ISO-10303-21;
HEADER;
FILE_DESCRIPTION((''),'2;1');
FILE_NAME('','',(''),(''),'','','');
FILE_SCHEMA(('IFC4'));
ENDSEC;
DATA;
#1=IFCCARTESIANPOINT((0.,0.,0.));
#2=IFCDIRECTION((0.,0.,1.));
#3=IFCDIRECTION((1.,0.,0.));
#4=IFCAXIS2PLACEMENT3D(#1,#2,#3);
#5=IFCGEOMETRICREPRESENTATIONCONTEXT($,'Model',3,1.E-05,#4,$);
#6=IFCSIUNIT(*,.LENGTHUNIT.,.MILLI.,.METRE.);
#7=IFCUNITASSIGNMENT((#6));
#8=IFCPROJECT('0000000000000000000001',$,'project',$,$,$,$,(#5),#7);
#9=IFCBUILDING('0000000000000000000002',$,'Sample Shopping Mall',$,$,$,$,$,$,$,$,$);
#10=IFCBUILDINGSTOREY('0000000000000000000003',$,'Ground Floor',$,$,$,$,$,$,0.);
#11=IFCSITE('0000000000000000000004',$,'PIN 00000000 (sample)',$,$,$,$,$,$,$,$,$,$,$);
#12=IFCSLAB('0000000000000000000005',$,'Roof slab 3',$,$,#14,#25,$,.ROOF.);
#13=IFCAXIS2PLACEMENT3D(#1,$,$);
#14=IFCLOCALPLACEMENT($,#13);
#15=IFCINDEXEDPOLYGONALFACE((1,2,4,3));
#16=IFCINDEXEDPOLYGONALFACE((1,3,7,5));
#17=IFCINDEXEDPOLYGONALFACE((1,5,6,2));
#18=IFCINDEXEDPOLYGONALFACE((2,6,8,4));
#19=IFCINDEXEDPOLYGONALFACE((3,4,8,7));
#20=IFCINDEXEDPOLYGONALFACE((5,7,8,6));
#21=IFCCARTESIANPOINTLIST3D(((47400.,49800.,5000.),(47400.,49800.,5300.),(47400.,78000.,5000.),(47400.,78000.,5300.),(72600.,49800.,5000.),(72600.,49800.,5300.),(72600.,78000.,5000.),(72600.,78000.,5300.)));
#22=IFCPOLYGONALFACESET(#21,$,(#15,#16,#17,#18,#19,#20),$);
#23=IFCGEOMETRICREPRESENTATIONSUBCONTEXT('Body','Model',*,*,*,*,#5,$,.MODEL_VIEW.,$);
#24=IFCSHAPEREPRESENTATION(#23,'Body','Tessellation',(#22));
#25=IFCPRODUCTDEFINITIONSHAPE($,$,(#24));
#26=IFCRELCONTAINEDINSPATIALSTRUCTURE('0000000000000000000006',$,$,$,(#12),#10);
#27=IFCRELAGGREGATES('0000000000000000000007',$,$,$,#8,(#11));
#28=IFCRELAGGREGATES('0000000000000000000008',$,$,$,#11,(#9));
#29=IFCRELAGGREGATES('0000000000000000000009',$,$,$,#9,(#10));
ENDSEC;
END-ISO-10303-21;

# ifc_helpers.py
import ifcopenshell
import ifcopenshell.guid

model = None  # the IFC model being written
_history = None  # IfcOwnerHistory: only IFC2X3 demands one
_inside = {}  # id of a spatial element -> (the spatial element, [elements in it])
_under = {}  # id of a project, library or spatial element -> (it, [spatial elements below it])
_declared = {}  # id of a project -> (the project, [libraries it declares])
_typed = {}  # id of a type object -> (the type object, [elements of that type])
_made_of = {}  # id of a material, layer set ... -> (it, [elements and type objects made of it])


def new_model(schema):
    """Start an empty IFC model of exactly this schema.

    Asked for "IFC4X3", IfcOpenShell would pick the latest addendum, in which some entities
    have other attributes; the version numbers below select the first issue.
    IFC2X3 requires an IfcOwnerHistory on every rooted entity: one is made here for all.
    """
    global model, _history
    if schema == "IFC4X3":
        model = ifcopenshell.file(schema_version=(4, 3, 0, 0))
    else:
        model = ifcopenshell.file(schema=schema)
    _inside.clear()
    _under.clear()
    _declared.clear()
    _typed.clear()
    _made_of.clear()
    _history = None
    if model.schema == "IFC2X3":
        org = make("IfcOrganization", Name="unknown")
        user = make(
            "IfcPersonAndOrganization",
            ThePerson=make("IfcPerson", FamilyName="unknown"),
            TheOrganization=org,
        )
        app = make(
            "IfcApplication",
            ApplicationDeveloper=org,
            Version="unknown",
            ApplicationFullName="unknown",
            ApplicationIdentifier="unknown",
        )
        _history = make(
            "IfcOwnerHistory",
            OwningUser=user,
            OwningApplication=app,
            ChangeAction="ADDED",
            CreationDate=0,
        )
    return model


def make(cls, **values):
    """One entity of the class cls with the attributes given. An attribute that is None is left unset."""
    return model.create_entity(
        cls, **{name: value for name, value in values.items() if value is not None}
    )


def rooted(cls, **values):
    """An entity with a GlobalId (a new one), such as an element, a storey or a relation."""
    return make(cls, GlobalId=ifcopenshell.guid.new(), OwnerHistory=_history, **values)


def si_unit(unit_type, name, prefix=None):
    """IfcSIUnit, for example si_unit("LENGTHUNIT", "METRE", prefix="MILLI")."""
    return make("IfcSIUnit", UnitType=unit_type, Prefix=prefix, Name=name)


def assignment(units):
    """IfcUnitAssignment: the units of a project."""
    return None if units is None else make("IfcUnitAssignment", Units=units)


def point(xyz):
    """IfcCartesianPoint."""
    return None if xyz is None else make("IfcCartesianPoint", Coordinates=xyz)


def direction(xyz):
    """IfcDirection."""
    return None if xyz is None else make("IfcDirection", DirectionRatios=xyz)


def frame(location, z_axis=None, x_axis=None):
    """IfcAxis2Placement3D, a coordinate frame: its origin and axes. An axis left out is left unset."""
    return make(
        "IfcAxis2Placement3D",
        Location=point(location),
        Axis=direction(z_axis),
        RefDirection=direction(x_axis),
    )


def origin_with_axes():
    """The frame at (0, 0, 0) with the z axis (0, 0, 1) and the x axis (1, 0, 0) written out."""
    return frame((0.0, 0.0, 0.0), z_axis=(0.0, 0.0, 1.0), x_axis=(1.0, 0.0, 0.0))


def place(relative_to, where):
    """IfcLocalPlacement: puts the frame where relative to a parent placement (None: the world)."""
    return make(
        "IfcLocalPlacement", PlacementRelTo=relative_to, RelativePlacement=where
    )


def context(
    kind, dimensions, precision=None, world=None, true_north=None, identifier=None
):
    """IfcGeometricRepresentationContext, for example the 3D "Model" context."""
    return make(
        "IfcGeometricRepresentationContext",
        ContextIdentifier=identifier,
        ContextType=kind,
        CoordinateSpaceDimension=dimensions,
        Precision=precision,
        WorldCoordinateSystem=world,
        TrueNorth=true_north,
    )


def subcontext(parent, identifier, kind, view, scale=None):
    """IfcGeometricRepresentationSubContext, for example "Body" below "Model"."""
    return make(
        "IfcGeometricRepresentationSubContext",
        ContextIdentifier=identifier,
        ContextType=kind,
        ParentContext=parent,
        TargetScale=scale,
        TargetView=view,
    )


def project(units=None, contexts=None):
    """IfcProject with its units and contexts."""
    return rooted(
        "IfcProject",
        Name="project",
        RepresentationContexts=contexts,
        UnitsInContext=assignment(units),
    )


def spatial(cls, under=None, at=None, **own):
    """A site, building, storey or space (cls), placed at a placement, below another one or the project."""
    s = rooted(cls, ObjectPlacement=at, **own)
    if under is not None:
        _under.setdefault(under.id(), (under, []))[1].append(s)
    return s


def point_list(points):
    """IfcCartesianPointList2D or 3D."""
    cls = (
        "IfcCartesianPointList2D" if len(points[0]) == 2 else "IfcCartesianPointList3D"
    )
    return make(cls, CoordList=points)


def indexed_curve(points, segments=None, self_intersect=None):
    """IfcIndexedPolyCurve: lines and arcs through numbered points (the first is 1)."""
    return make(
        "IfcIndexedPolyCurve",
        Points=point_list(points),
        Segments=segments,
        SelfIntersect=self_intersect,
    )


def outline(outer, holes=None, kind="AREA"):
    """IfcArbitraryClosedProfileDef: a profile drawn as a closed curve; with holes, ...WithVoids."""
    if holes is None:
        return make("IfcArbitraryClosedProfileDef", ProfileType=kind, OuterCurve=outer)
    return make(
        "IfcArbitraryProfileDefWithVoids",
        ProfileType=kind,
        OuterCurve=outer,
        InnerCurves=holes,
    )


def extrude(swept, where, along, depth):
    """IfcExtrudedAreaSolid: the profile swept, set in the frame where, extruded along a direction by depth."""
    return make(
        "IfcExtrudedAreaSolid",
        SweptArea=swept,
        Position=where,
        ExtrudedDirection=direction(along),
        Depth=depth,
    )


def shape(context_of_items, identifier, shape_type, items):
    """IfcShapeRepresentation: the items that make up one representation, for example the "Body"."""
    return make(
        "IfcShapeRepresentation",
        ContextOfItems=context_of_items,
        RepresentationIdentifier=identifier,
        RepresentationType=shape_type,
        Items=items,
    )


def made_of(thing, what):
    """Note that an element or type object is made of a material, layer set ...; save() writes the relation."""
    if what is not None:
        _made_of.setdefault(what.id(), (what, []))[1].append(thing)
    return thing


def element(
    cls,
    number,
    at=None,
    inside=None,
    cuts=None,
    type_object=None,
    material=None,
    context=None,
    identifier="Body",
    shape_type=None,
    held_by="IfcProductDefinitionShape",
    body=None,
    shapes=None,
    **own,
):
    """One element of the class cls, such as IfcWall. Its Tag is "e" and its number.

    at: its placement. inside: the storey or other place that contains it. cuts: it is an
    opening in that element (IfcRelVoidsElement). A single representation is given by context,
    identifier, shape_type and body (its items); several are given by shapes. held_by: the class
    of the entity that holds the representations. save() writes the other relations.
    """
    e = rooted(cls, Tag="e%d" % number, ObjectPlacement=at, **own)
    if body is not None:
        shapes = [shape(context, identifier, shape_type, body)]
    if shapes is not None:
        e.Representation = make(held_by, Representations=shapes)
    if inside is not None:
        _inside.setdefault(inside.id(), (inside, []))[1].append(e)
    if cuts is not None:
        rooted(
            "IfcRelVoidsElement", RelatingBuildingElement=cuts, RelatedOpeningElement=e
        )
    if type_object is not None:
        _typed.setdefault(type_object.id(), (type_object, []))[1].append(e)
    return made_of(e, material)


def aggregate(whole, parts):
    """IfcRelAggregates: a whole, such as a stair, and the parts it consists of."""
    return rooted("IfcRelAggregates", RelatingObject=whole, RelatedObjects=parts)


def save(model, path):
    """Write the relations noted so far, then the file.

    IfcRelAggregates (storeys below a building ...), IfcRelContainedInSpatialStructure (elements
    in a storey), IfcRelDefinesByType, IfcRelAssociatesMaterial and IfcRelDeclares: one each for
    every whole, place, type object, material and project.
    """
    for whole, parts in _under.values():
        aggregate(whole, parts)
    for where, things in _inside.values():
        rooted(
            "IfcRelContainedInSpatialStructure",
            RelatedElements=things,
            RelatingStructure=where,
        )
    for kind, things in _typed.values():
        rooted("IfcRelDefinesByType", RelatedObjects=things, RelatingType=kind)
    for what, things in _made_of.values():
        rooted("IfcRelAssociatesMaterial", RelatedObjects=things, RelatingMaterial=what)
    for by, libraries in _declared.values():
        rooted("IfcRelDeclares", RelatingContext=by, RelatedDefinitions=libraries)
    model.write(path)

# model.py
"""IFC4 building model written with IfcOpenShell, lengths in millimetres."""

from ifc_helpers import new_model, si_unit, frame, origin_with_axes, place, context, subcontext, project, spatial, indexed_curve, outline, extrude, element, save


model = new_model("IFC4")

# Units and contexts
model_context = context("Model", 3, precision=1e-05, world=origin_with_axes())
body_context = subcontext(model_context, "Body", "Model", "MODEL_VIEW")
ifc_project = project(units=[si_unit("LENGTHUNIT", "METRE", prefix="MILLI")], contexts=[model_context])

# Site, building, storey
site = spatial("IfcSite", under=ifc_project, Name="PIN 00000000 (sample)")
building = spatial("IfcBuilding", under=site, Name="Sample Shopping Mall")
storey = spatial("IfcBuildingStorey", under=building, Name="Ground Floor", Elevation=0.0)

# Slab
slab_placement = place(None, frame((0.0, 0.0, 5000.0), z_axis=(0.0, 0.0, 1.0), x_axis=(1.0, 0.0, 0.0)))
element("IfcSlab", 1, at=slab_placement, inside=storey, Name="Roof slab 3", PredefinedType="ROOF", context=body_context, shape_type="SweptSolid", body=[
    extrude(outline(indexed_curve([(47400.0, 49800.0), (72600.0, 49800.0), (72600.0, 78000.0), (47400.0, 78000.0)])), None, (0.0, 0.0, 1.0), 300.0),
])

save(model, "model.ifc")
